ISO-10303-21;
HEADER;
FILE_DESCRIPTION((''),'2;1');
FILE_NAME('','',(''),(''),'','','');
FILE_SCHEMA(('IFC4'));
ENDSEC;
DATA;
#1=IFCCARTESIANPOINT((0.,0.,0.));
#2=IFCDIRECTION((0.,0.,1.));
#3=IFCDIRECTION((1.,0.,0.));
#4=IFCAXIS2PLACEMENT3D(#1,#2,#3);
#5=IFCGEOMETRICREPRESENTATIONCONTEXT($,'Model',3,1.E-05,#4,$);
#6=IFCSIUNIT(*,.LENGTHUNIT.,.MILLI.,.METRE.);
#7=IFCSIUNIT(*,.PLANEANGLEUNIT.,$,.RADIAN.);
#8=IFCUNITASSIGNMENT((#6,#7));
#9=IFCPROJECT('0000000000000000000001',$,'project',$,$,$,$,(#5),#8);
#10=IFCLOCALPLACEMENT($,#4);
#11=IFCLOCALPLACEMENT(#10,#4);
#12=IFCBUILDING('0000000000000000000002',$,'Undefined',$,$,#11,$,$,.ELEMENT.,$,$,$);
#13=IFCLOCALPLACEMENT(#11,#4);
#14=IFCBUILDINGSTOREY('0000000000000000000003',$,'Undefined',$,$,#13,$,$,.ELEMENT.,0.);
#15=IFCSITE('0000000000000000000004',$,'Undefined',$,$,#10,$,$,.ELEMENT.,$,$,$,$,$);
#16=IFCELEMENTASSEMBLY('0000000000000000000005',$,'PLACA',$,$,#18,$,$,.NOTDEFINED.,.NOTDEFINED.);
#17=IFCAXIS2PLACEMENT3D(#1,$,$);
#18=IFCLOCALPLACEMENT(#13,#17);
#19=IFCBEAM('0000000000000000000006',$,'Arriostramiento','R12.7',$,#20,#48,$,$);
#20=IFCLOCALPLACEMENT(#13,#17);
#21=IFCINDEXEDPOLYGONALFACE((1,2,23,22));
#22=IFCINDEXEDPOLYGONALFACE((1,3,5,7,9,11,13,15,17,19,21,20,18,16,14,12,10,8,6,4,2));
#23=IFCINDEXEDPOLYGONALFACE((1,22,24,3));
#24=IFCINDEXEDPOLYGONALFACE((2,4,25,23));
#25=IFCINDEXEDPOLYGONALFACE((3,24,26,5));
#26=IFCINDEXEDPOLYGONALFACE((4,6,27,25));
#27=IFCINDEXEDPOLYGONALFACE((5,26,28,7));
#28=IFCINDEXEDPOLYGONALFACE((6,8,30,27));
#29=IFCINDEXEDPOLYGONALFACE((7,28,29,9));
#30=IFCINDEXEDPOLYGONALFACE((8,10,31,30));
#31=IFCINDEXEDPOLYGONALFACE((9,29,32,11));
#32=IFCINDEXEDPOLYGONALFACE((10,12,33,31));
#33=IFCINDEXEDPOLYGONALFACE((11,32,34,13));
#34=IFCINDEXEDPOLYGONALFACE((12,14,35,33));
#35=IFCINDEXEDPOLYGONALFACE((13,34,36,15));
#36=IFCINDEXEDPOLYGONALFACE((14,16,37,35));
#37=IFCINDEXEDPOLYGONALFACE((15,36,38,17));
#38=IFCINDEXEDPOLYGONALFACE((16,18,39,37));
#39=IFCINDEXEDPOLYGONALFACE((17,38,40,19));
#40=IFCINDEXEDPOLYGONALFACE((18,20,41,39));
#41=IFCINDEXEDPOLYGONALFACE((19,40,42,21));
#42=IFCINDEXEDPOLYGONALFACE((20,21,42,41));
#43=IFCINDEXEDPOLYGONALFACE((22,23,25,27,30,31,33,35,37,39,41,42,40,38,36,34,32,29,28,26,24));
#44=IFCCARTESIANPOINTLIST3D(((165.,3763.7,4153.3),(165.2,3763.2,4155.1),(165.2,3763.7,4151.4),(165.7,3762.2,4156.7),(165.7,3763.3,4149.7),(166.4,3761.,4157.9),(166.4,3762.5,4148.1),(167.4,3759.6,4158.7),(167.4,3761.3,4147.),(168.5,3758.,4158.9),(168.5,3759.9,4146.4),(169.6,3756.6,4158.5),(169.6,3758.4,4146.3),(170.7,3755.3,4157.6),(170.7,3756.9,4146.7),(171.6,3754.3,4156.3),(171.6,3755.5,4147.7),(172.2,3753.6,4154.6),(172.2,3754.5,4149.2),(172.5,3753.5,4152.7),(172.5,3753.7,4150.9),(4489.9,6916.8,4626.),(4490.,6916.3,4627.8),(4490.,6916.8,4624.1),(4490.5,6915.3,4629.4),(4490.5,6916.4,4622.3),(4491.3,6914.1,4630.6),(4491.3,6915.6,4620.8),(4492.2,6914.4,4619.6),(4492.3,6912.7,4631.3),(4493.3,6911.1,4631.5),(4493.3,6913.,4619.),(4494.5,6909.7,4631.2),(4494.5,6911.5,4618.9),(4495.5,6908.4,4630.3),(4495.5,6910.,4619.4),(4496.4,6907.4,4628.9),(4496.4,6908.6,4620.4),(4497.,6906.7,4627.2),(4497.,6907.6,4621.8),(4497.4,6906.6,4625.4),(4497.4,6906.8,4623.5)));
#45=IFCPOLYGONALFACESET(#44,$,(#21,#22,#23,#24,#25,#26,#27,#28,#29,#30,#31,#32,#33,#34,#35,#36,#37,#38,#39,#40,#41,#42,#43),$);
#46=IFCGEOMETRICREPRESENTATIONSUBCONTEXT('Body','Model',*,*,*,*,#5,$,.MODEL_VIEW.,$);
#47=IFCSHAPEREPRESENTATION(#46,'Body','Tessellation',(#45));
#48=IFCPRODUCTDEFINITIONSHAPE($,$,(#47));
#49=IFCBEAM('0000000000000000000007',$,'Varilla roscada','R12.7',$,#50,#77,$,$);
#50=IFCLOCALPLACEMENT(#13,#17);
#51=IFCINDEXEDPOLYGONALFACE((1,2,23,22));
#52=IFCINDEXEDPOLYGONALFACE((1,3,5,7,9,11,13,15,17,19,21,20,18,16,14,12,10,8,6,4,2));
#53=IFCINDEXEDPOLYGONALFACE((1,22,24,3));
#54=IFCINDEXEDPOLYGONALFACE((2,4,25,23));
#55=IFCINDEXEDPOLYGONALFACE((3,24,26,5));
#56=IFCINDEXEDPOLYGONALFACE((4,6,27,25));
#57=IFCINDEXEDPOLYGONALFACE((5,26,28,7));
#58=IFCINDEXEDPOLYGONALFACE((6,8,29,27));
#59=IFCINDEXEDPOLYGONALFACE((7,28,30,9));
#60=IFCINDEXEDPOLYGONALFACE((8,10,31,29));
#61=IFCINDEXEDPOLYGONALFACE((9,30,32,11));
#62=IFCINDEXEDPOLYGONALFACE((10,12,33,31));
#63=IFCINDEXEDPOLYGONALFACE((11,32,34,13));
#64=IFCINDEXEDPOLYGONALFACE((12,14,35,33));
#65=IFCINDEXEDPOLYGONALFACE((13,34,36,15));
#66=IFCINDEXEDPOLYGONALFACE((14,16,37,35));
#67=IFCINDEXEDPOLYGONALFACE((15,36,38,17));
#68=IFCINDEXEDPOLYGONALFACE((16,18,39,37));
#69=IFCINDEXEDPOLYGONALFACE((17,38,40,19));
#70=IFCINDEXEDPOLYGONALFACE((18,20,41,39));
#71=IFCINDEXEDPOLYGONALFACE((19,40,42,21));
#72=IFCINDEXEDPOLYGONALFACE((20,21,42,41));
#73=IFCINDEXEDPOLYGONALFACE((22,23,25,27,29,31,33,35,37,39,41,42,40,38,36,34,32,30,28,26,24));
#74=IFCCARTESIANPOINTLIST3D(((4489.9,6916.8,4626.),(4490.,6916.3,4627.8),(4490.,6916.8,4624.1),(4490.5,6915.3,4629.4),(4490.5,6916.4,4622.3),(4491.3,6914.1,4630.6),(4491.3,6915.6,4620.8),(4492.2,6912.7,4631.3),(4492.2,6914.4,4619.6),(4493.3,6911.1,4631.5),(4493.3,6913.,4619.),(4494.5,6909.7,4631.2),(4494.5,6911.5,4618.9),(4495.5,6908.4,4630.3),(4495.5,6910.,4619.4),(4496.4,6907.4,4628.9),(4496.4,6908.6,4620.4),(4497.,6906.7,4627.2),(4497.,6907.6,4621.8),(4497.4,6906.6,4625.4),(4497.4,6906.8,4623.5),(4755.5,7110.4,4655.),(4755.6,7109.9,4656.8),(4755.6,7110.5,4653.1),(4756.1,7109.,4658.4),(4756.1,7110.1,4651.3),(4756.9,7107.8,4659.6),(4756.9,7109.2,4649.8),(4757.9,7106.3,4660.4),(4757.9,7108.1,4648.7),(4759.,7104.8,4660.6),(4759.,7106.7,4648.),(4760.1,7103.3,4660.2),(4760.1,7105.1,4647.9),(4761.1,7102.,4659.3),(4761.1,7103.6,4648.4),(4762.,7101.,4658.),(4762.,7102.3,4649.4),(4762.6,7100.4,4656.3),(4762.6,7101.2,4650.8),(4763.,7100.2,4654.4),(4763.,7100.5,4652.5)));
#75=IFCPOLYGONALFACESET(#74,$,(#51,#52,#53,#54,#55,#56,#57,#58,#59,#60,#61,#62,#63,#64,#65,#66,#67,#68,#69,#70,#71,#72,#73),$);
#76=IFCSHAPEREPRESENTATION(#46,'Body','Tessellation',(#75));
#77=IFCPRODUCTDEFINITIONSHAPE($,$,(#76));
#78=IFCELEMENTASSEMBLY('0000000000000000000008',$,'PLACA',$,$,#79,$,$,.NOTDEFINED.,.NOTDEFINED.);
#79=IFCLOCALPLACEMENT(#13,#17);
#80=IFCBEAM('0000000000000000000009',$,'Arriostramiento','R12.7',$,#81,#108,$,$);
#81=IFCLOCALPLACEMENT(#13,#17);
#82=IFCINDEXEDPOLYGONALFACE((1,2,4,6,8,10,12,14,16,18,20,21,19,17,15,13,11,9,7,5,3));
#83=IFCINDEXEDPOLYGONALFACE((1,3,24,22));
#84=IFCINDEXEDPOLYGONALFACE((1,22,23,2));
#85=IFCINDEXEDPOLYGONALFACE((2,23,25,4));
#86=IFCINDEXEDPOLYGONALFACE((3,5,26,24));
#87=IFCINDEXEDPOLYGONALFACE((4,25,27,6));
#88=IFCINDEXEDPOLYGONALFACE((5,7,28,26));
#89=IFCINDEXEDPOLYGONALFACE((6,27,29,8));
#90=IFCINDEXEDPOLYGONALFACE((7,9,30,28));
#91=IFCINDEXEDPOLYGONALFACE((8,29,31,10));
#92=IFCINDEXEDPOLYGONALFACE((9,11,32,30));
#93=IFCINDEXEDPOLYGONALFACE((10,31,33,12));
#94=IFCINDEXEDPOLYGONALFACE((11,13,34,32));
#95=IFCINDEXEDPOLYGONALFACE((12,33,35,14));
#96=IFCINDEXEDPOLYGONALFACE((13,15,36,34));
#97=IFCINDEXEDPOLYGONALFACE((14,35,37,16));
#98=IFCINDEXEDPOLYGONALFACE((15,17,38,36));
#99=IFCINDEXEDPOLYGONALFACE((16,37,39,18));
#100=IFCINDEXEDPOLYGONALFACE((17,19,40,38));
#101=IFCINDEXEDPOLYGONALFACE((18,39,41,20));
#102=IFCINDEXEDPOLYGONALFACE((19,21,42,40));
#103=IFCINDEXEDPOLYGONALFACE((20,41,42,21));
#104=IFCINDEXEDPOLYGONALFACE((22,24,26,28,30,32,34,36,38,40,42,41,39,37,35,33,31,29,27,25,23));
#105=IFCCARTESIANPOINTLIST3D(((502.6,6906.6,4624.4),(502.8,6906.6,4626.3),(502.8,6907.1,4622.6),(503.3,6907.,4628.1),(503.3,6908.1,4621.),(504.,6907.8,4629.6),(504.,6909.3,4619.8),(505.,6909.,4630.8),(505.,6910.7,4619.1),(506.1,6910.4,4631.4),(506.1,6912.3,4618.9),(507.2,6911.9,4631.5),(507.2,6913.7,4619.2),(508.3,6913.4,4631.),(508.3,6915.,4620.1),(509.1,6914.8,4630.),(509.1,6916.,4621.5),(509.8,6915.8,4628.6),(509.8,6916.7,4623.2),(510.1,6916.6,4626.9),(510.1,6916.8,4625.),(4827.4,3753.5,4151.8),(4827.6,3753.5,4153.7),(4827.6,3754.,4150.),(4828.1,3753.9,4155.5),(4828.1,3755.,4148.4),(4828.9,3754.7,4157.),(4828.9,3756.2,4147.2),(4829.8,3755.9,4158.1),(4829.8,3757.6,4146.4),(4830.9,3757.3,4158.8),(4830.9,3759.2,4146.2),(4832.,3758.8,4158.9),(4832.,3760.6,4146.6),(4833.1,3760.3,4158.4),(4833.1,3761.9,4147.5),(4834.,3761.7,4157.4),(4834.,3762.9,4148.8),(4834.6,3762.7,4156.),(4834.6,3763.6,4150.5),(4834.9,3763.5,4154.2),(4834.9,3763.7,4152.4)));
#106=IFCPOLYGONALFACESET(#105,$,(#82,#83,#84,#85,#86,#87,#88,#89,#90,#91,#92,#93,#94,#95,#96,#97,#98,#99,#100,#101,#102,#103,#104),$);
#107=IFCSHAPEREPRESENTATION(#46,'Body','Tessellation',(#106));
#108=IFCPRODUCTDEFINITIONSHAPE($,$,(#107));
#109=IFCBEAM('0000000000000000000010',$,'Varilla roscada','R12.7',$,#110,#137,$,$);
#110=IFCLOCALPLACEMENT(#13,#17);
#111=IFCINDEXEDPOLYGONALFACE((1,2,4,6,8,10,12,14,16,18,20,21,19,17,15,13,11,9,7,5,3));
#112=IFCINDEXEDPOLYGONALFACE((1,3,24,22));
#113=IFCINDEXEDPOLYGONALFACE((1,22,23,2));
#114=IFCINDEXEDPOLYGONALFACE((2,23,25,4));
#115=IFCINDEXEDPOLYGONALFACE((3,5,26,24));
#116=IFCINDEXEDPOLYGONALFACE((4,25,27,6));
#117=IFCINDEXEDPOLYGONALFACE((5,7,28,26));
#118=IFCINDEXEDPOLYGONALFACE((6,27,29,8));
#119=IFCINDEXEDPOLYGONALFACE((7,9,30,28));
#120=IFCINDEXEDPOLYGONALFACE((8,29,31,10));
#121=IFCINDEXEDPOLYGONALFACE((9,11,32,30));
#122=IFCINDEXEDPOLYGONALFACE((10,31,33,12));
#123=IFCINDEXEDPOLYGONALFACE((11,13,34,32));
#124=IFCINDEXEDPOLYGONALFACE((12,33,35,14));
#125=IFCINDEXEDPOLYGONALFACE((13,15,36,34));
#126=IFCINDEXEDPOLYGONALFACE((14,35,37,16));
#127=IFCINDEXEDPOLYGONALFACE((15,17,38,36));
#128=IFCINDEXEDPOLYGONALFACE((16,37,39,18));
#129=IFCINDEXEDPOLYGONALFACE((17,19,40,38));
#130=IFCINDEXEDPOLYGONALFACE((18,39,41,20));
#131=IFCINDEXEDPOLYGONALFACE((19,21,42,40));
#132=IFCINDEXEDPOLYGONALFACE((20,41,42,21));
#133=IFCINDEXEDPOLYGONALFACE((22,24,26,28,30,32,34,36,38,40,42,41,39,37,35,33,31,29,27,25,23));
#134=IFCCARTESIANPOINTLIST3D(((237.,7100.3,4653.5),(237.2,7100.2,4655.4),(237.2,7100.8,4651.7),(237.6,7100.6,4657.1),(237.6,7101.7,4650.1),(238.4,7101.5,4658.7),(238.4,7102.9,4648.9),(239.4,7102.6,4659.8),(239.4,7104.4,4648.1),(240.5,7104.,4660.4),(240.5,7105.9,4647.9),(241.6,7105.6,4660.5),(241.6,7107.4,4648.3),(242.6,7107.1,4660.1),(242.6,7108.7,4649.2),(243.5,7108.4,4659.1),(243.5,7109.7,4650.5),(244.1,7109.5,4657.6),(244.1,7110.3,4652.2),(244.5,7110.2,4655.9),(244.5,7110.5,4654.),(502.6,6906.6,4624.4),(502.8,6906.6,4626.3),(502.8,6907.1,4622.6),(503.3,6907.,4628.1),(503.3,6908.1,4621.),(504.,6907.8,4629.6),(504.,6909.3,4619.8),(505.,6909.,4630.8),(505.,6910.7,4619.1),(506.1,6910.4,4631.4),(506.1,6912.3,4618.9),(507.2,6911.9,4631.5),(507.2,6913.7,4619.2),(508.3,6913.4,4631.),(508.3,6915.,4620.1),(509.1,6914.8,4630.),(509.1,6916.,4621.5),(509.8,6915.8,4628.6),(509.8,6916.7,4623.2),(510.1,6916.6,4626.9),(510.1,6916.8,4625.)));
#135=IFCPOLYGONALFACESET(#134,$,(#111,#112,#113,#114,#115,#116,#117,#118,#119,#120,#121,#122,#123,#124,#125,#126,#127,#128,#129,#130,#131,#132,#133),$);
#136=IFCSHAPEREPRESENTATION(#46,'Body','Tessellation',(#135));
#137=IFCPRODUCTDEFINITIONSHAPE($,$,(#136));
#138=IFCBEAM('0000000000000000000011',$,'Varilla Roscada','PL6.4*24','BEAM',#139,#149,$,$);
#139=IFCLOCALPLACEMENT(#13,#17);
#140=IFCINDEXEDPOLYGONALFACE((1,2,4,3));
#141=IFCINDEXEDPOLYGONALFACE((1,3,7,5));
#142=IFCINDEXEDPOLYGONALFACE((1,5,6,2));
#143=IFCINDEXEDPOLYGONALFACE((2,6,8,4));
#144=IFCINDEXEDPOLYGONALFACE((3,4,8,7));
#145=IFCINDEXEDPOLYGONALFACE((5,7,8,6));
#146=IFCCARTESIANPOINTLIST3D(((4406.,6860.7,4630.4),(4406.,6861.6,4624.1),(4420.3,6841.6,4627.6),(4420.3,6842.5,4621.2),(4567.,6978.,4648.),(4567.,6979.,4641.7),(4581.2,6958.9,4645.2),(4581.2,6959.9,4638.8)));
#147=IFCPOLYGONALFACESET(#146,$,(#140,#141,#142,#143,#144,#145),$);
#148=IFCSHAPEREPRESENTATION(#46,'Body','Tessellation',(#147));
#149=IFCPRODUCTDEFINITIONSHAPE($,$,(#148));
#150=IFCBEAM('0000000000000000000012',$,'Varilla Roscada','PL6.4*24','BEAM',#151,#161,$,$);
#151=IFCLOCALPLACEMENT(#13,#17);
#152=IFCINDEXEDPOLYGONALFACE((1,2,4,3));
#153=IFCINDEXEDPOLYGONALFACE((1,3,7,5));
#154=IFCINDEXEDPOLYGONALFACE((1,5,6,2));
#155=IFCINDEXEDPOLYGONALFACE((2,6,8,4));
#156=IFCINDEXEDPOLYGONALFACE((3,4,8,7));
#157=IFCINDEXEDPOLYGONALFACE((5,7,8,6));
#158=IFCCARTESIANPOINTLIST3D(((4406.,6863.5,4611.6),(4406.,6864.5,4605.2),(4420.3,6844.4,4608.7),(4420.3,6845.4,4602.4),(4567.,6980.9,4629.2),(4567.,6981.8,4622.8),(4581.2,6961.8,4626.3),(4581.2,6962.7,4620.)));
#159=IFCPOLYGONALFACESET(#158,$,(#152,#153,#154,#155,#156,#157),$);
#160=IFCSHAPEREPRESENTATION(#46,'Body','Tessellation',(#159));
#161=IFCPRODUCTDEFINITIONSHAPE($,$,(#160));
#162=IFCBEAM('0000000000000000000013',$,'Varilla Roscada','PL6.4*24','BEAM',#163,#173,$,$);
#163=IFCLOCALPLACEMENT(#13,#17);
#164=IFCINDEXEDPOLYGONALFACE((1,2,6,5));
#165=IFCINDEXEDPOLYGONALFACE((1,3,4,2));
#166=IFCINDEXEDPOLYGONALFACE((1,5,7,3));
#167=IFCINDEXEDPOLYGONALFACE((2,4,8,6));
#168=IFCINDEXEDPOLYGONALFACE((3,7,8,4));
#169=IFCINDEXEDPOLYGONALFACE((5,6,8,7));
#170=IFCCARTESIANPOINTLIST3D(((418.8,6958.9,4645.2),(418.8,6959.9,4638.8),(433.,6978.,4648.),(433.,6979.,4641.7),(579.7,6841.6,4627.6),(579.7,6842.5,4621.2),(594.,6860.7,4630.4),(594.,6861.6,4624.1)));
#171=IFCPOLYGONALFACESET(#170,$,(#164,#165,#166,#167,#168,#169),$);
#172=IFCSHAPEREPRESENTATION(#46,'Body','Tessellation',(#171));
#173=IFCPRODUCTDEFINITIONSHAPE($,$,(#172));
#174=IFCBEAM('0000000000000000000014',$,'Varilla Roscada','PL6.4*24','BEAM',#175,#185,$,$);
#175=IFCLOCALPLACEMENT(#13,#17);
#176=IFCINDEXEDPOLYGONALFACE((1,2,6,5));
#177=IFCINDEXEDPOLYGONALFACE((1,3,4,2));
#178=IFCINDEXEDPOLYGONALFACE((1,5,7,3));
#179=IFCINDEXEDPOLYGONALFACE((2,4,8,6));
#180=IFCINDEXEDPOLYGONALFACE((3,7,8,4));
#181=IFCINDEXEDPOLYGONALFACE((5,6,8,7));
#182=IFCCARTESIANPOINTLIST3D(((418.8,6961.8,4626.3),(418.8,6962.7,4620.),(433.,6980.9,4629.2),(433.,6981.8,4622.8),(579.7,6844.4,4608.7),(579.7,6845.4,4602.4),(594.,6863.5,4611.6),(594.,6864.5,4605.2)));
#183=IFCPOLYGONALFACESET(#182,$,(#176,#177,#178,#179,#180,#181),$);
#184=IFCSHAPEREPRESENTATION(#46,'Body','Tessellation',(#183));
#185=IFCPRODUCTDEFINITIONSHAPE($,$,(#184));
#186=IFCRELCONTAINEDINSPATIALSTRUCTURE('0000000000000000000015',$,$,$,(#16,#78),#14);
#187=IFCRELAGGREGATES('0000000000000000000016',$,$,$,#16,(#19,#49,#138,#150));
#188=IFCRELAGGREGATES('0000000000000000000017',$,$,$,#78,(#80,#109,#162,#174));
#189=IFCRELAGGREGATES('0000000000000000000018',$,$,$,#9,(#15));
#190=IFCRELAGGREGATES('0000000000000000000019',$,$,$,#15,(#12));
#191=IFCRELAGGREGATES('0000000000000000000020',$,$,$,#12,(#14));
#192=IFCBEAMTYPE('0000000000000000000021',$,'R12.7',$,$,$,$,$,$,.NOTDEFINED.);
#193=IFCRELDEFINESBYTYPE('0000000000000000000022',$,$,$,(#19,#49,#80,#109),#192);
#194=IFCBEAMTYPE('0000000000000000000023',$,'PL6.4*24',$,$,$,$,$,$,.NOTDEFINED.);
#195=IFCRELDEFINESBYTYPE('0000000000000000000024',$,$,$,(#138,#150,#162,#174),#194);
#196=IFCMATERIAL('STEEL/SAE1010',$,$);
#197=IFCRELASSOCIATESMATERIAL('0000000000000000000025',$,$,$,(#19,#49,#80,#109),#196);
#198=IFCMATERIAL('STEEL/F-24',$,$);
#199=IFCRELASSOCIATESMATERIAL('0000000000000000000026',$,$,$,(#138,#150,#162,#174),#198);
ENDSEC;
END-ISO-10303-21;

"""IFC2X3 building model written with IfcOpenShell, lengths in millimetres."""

from ifc_helpers import new_model, si_unit, frame, origin_with_axes, origin_2d_with_axis, place, context, subcontext, project, spatial, rectangle, circle, extrude, material, type_object, element, aggregate, save


model = new_model("IFC2X3")

# Units and contexts
model_context = context("Model", 3, precision=1e-05, world=origin_with_axes())
body_context = subcontext(model_context, "Body", "Model", "MODEL_VIEW")
ifc_project = project(units=[si_unit("LENGTHUNIT", "METRE", prefix="MILLI"), si_unit("PLANEANGLEUNIT", "RADIAN")], contexts=[model_context])

# Site, building, storey
site_placement = place(None, origin_with_axes())
site = spatial("IfcSite", under=ifc_project, at=site_placement, Name="Undefined", CompositionType="ELEMENT")
building_placement = place(site_placement, origin_with_axes())
building = spatial("IfcBuilding", under=site, at=building_placement, Name="Undefined", CompositionType="ELEMENT")
storey_placement = place(building_placement, origin_with_axes())
storey = spatial("IfcBuildingStorey", under=building, at=storey_placement, Name="Undefined", CompositionType="ELEMENT", Elevation=0.0)

# Element assemblies, beams
assembly_1_placement = place(storey_placement, origin_with_axes())
assembly_1 = element("IfcElementAssembly", 1, at=assembly_1_placement, inside=storey, Name="PLACA", AssemblyPlace="NOTDEFINED", PredefinedType="NOTDEFINED")
ifc_material_1 = material(Name="STEEL/SAE1010")
beam_type_1 = type_object("IfcBeamType", Name="R12.7", PredefinedType="NOTDEFINED")
beam_1_placement = place(assembly_1_placement, frame((4493.6, 6911.7, 4625.2), z_axis=(0.000047, -0.148304, 0.988942), x_axis=(-0.804913, -0.586837, -0.087965)))
beam_1 = element("IfcBeam", 2, at=beam_1_placement, type_object=beam_type_1, material=ifc_material_1, Name="Arriostramiento", Description="R12.7", context=body_context, shape_type="SweptSolid", body=[
    extrude(circle(Radius=6.3, at=origin_2d_with_axis()), frame((5373.0, 0.0, 0.0), z_axis=(-1.0, 0.0, 0.0), x_axis=(0.0, -1.0, 0.0)), (0.0, 0.0, 1.0), 5373.0),
])
beam_2_placement = place(assembly_1_placement, frame((4759.2, 7105.4, 4654.2), z_axis=(0.00003, -0.148316, 0.98894), x_axis=(-0.804914, -0.586833, -0.087985)))
beam_2 = element("IfcBeam", 3, at=beam_2_placement, type_object=beam_type_1, material=ifc_material_1, Name="Varilla roscada", Description="R12.7", context=body_context, shape_type="SweptSolid", body=[
    extrude(circle(Radius=6.3, at=origin_2d_with_axis()), frame((330.0, 0.0, 0.0), z_axis=(-1.0, 0.0, 0.0), x_axis=(0.0, -1.0, 0.0)), (0.0, 0.0, 1.0), 330.0),
])
assembly_2_placement = place(storey_placement, origin_with_axes())
assembly_2 = element("IfcElementAssembly", 4, at=assembly_2_placement, inside=storey, Name="PLACA", AssemblyPlace="NOTDEFINED", PredefinedType="NOTDEFINED")
beam_3_placement = place(assembly_2_placement, frame((506.4, 6911.7, 4625.2), z_axis=(-0.000047, -0.148304, 0.988942), x_axis=(0.804913, -0.586837, -0.087965)))
beam_3 = element("IfcBeam", 5, at=beam_3_placement, type_object=beam_type_1, material=ifc_material_1, Name="Arriostramiento", Description="R12.7", context=body_context, shape_type="SweptSolid", body=[
    extrude(circle(Radius=6.3, at=origin_2d_with_axis()), frame((5373.0, 0.0, 0.0), z_axis=(-1.0, 0.0, 0.0), x_axis=(0.0, -1.0, 0.0)), (0.0, 0.0, 1.0), 5373.0),
])
beam_4_placement = place(assembly_2_placement, frame((240.8, 7105.4, 4654.2), z_axis=(-0.00003, -0.148316, 0.98894), x_axis=(0.804914, -0.586833, -0.087985)))
beam_4 = element("IfcBeam", 6, at=beam_4_placement, type_object=beam_type_1, material=ifc_material_1, Name="Varilla roscada", Description="R12.7", context=body_context, shape_type="SweptSolid", body=[
    extrude(circle(Radius=6.3, at=origin_2d_with_axis()), frame((330.0, 0.0, 0.0), z_axis=(-1.0, 0.0, 0.0), x_axis=(0.0, -1.0, 0.0)), (0.0, 0.0, 1.0), 330.0),
])

# Beams
ifc_material_2 = material(Name="STEEL/F-24")
beam_type_2 = type_object("IfcBeamType", Name="PL6.4*24", PredefinedType="NOTDEFINED")
beam_5_placement = place(assembly_1_placement, frame((4413.1, 6851.6, 4625.8), z_axis=(-0.593392, 0.796009, 0.119399), x_axis=(0.804914, 0.586833, 0.087985)))
beam_5 = element("IfcBeam", 7, at=beam_5_placement, type_object=beam_type_2, material=ifc_material_2, Name="Varilla Roscada", Description="PL6.4*24", ObjectType="BEAM", context=body_context, shape_type="SweptSolid", body=[
    extrude(rectangle(XDim=6.4, YDim=24.0, at=origin_2d_with_axis()), frame((200.0, 0.0, 0.0), z_axis=(-1.0, 0.0, 0.0), x_axis=(0.0, -1.0, 0.0)), (0.0, 0.0, 1.0), 200.0),
])
beam_6_placement = place(assembly_1_placement, frame((4413.1, 6854.4, 4607.0), z_axis=(-0.593392, 0.796009, 0.119399), x_axis=(0.804914, 0.586833, 0.087985)))
beam_6 = element("IfcBeam", 8, at=beam_6_placement, type_object=beam_type_2, material=ifc_material_2, Name="Varilla Roscada", Description="PL6.4*24", ObjectType="BEAM", context=body_context, shape_type="SweptSolid", body=[
    extrude(rectangle(XDim=6.4, YDim=24.0, at=origin_2d_with_axis()), frame((200.0, 0.0, 0.0), z_axis=(-1.0, 0.0, 0.0), x_axis=(0.0, -1.0, 0.0)), (0.0, 0.0, 1.0), 200.0),
])
aggregate(assembly_1, [beam_1, beam_2, beam_5, beam_6])
beam_7_placement = place(assembly_2_placement, frame((586.9, 6851.6, 4625.8), z_axis=(0.593392, 0.796009, 0.119399), x_axis=(-0.804914, 0.586833, 0.087985)))
beam_7 = element("IfcBeam", 9, at=beam_7_placement, type_object=beam_type_2, material=ifc_material_2, Name="Varilla Roscada", Description="PL6.4*24", ObjectType="BEAM", context=body_context, shape_type="SweptSolid", body=[
    extrude(rectangle(XDim=6.4, YDim=24.0, at=origin_2d_with_axis()), frame((200.0, 0.0, 0.0), z_axis=(-1.0, 0.0, 0.0), x_axis=(0.0, -1.0, 0.0)), (0.0, 0.0, 1.0), 200.0),
])
beam_8_placement = place(assembly_2_placement, frame((586.9, 6854.4, 4607.0), z_axis=(0.593392, 0.796009, 0.119399), x_axis=(-0.804914, 0.586833, 0.087985)))
beam_8 = element("IfcBeam", 10, at=beam_8_placement, type_object=beam_type_2, material=ifc_material_2, Name="Varilla Roscada", Description="PL6.4*24", ObjectType="BEAM", context=body_context, shape_type="SweptSolid", body=[
    extrude(rectangle(XDim=6.4, YDim=24.0, at=origin_2d_with_axis()), frame((200.0, 0.0, 0.0), z_axis=(-1.0, 0.0, 0.0), x_axis=(0.0, -1.0, 0.0)), (0.0, 0.0, 1.0), 200.0),
])
aggregate(assembly_2, [beam_3, beam_4, beam_7, beam_8])

save(model, "model.ifc")
